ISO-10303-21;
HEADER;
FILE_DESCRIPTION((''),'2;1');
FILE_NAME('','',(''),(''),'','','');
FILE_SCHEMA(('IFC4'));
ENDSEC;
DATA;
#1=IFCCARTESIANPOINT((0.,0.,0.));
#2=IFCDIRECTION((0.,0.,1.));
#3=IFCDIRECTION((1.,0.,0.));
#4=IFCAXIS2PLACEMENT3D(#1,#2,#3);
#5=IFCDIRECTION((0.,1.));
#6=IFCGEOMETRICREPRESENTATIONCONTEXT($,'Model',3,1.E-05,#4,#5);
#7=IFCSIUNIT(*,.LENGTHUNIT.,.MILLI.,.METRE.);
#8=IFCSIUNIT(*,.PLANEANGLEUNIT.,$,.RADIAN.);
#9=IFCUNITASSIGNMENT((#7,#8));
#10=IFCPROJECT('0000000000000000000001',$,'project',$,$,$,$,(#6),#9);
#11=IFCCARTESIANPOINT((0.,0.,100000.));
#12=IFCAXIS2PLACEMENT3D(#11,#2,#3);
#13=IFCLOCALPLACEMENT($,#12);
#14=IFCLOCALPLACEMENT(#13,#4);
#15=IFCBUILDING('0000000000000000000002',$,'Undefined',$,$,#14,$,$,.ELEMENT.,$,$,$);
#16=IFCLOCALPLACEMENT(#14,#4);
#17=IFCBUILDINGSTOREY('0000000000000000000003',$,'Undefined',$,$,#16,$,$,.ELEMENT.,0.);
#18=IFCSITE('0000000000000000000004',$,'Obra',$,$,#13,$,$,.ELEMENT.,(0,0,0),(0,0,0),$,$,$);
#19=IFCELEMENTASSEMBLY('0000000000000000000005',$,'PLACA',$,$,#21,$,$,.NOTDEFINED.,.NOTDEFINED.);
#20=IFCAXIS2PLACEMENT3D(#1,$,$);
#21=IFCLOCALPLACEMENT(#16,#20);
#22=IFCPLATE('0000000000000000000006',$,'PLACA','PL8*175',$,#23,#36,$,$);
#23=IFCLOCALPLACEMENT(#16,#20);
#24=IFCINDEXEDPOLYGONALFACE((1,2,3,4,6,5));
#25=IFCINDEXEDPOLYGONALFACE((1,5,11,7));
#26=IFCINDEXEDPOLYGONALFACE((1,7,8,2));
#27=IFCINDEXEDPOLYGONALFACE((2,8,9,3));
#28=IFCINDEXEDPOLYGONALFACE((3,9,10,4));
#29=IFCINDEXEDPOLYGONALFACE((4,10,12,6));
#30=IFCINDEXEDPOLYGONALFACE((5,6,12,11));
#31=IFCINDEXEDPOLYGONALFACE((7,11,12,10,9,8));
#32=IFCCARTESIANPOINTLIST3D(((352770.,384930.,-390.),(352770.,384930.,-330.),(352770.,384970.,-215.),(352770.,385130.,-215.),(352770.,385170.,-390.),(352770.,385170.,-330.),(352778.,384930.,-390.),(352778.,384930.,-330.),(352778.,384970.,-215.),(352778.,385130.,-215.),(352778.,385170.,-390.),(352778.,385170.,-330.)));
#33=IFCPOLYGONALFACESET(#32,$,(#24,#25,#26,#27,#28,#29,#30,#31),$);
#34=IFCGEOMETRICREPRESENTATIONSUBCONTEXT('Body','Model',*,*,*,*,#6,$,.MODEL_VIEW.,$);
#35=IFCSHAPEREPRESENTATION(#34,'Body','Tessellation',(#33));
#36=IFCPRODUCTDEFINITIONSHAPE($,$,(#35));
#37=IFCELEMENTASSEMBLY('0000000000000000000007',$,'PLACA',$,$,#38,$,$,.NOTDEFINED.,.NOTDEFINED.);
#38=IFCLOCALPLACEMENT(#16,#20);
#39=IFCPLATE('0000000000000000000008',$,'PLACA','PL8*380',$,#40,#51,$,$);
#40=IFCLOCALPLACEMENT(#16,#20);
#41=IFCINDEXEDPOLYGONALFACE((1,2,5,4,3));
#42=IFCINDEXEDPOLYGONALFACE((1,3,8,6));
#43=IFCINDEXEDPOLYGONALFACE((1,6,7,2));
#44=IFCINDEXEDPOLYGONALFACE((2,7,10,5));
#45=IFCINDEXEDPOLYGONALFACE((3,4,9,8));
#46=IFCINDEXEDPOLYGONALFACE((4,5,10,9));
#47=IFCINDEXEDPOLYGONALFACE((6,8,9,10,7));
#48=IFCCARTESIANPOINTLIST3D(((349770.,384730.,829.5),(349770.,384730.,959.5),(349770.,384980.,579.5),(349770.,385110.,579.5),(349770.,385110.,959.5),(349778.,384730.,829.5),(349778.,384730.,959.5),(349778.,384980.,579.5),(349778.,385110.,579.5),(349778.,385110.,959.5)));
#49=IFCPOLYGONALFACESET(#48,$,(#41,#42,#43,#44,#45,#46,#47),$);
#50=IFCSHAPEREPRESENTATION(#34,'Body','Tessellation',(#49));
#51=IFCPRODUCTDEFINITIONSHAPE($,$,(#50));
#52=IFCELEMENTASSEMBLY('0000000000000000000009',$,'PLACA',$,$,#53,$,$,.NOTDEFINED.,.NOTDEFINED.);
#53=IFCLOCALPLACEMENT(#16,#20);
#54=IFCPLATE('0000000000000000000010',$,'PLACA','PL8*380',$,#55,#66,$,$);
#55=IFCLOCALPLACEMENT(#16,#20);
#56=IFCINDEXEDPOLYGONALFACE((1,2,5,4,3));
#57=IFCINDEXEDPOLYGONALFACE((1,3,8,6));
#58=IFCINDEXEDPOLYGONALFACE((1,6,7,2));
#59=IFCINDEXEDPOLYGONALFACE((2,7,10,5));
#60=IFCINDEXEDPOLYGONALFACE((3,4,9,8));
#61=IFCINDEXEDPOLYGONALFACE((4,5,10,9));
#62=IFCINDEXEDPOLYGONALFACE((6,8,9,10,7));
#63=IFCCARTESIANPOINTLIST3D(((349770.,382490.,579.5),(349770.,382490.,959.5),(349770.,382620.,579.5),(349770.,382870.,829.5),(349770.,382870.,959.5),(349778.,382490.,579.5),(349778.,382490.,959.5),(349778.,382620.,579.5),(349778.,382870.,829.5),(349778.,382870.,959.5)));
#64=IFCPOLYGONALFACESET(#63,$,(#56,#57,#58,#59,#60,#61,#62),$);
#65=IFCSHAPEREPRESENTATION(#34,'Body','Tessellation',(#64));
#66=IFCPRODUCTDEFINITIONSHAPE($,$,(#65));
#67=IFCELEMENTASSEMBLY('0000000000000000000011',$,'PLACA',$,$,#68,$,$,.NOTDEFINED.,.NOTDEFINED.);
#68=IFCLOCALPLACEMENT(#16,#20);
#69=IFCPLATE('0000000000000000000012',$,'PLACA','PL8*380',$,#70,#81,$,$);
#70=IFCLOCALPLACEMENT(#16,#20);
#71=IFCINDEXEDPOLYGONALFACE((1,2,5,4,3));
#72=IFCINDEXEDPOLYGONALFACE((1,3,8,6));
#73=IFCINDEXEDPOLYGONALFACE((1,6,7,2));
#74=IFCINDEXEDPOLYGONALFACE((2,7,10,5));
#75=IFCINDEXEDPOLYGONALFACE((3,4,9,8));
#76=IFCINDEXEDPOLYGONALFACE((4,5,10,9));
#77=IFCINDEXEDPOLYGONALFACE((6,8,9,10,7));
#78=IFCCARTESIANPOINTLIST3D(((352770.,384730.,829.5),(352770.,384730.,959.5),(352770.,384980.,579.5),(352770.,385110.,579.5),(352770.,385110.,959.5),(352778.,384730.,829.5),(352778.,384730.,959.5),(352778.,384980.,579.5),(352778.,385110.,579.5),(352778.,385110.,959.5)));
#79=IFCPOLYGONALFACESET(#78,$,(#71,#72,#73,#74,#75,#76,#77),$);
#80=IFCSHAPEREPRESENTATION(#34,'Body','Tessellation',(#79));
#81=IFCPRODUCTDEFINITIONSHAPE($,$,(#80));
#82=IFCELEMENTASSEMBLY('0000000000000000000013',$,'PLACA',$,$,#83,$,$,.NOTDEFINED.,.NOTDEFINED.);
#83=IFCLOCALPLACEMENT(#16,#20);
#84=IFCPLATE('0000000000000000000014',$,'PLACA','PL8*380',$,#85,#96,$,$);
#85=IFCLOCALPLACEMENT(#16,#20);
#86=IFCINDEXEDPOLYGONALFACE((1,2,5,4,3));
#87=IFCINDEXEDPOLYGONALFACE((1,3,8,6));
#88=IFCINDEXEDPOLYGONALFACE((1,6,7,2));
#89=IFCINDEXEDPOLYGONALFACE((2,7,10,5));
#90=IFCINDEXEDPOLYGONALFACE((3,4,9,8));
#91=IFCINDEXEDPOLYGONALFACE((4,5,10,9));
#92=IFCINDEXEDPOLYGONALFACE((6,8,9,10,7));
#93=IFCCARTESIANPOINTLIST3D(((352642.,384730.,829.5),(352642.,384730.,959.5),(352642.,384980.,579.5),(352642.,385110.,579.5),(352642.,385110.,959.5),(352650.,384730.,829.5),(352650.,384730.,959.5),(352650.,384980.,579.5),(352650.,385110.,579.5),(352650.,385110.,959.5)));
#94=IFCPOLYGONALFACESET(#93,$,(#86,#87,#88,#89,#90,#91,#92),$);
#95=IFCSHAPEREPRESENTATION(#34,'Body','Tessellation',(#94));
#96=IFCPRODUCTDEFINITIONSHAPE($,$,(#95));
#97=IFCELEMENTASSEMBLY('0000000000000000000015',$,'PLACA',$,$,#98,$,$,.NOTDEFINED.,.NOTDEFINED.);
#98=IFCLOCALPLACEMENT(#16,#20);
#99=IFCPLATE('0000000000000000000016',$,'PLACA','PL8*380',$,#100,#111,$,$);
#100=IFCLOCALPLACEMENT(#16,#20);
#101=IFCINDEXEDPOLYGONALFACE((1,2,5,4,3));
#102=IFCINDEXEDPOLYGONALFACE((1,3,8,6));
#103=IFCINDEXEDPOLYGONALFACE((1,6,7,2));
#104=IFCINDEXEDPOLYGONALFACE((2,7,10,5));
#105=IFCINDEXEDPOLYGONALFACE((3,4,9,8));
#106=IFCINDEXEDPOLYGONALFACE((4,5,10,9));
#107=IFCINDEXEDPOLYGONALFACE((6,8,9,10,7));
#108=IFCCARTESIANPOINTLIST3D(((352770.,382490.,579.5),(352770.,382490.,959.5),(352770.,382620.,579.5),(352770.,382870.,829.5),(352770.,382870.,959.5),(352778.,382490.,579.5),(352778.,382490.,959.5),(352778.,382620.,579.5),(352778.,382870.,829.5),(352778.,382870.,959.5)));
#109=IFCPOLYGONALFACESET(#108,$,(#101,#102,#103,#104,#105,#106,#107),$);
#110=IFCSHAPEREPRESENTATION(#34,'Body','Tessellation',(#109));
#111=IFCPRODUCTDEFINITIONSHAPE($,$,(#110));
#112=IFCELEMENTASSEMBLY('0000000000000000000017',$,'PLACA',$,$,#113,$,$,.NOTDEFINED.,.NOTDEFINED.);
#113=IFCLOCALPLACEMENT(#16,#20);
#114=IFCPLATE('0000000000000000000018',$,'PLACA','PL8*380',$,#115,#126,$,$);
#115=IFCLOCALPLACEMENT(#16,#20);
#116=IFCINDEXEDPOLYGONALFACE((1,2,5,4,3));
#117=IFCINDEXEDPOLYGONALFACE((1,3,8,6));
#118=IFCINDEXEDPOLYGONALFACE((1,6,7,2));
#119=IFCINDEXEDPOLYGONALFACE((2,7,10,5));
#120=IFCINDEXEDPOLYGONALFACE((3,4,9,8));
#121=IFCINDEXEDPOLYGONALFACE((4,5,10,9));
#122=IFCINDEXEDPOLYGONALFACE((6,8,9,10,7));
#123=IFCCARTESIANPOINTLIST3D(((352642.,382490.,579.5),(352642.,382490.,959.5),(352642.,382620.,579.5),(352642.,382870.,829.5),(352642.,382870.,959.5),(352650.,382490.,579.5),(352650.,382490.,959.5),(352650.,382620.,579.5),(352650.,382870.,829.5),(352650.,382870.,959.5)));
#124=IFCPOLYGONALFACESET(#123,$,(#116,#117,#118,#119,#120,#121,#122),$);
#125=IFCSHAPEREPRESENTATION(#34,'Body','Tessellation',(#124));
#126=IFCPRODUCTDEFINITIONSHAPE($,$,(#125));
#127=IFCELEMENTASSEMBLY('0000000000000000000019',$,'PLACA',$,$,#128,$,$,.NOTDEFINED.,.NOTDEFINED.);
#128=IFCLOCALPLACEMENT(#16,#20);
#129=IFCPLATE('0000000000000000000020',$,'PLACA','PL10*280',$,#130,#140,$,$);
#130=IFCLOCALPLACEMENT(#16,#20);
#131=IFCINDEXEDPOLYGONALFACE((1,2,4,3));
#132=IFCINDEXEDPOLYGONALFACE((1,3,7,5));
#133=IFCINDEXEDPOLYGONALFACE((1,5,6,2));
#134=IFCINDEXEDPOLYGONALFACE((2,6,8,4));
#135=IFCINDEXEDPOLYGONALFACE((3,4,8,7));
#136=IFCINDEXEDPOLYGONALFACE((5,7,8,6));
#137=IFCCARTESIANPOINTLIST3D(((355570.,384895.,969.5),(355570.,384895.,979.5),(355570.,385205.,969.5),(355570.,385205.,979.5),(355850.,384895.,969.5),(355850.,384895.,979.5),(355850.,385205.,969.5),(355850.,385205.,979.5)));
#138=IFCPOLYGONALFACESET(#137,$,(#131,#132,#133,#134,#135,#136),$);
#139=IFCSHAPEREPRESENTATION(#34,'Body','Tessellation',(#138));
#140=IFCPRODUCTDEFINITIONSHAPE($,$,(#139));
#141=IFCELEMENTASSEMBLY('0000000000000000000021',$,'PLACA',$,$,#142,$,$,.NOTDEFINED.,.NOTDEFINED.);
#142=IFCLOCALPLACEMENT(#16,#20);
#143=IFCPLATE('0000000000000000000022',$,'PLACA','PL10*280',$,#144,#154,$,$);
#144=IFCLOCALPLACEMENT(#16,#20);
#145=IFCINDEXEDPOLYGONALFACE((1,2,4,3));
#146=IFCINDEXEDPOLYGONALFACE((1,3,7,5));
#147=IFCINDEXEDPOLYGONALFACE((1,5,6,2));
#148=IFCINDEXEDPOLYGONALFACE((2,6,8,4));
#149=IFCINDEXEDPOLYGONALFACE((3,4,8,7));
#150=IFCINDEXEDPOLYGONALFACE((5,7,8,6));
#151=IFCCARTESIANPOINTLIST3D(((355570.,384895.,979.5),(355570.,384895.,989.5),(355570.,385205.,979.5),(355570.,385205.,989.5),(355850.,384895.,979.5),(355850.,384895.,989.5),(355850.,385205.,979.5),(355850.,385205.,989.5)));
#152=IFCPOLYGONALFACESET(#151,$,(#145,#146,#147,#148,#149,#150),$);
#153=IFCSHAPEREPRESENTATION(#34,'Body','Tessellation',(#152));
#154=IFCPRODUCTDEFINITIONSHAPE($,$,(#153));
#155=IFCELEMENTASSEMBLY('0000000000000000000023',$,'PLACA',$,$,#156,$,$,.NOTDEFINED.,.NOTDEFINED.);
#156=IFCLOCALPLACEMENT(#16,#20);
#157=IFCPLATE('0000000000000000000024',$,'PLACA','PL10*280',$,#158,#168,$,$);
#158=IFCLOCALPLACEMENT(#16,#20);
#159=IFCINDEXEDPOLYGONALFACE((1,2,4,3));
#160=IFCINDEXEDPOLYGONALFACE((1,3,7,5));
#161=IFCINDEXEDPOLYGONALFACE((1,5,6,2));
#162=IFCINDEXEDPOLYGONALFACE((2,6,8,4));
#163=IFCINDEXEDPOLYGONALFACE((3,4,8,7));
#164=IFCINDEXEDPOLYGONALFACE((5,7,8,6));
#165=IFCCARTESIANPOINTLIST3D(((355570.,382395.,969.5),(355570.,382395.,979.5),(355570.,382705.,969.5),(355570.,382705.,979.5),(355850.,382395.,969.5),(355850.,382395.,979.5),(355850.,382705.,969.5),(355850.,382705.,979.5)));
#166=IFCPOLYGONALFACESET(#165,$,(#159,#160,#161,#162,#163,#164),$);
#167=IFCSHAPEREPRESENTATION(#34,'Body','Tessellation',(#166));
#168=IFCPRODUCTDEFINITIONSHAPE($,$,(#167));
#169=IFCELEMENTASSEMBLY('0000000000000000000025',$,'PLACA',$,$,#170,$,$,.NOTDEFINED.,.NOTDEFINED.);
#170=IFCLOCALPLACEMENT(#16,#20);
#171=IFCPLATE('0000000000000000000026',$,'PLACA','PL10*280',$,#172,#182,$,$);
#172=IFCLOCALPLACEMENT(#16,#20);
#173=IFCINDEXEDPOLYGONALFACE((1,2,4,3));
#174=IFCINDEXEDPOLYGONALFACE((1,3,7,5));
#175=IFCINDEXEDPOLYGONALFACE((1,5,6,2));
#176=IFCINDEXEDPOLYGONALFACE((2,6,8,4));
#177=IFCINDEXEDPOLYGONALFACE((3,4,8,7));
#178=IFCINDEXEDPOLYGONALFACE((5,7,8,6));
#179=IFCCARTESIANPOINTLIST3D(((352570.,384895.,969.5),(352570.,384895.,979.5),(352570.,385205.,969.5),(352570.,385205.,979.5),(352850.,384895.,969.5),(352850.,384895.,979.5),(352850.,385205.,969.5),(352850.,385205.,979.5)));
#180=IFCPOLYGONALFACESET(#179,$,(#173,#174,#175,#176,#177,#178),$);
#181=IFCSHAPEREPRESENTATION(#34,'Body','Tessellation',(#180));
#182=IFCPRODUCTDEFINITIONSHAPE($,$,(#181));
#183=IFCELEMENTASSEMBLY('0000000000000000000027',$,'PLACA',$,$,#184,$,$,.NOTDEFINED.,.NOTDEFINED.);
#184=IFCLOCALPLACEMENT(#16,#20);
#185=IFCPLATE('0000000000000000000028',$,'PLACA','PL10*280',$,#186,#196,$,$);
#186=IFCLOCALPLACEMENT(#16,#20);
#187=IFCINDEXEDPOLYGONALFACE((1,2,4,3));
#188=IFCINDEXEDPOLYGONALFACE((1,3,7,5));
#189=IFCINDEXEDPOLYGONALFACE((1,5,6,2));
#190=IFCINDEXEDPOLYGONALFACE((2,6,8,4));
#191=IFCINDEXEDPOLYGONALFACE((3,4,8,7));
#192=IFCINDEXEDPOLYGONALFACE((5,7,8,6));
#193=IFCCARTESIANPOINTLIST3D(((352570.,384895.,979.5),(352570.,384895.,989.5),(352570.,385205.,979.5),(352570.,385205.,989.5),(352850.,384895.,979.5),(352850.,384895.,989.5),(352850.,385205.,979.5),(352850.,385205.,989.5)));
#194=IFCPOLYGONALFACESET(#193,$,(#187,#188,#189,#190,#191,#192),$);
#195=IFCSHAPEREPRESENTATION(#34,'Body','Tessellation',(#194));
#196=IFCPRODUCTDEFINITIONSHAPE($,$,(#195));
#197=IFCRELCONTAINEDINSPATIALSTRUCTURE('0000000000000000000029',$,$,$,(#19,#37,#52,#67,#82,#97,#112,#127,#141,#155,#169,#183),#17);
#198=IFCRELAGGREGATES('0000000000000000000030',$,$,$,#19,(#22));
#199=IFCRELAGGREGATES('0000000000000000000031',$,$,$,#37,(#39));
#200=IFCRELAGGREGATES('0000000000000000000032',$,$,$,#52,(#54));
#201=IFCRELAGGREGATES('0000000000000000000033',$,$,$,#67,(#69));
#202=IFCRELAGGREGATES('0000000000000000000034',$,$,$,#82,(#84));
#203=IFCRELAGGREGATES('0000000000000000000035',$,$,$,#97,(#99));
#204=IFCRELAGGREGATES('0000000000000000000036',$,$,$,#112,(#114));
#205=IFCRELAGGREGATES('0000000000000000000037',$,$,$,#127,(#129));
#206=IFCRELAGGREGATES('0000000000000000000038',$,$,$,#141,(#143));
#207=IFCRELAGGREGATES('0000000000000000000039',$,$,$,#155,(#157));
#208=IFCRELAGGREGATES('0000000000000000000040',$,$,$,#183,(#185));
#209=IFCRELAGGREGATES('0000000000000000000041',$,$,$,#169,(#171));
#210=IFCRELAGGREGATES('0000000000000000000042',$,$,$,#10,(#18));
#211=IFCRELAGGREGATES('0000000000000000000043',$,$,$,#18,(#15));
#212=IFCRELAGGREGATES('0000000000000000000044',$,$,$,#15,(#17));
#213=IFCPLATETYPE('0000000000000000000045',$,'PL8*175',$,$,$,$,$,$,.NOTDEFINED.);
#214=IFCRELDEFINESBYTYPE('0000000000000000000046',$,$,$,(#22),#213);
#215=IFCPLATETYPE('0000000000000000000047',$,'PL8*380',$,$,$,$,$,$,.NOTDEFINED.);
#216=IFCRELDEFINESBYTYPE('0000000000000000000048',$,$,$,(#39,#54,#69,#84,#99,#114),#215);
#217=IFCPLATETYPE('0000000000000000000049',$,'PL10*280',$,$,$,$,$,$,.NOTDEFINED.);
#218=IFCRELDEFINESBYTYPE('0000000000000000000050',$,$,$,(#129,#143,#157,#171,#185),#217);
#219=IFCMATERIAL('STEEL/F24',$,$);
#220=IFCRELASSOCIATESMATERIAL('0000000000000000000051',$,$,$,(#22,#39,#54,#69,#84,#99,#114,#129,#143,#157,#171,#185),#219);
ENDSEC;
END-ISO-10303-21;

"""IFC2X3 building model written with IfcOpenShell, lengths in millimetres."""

from ifc_helpers import new_model, si_unit, direction, frame, origin_with_axes, place, context, subcontext, project, spatial, polyline, outline, extrude, material, type_object, element, aggregate, save


model = new_model("IFC2X3")

# Units and contexts
model_context = context("Model", 3, precision=1e-05, world=origin_with_axes(), true_north=direction((0.0, 1.0)))
body_context = subcontext(model_context, "Body", "Model", "MODEL_VIEW")
ifc_project = project(units=[si_unit("LENGTHUNIT", "METRE", prefix="MILLI"), si_unit("PLANEANGLEUNIT", "RADIAN")], contexts=[model_context])

# Site, building, storey
site_placement = place(None, frame((0.0, 0.0, 100000.0), z_axis=(0.0, 0.0, 1.0), x_axis=(1.0, 0.0, 0.0)))
site = spatial("IfcSite", under=ifc_project, at=site_placement, Name="Obra", CompositionType="ELEMENT", RefLatitude=(0, 0, 0), RefLongitude=(0, 0, 0))
building_placement = place(site_placement, origin_with_axes())
building = spatial("IfcBuilding", under=site, at=building_placement, Name="Undefined", CompositionType="ELEMENT")
storey_placement = place(building_placement, origin_with_axes())
storey = spatial("IfcBuildingStorey", under=building, at=storey_placement, Name="Undefined", CompositionType="ELEMENT", Elevation=0.0)

# Shared definitions
ifc_material_1 = material(Name="STEEL/F24")

# Element assemblies, plates
plate_type_1 = type_object("IfcPlateType", Name="PL8*175", PredefinedType="NOTDEFINED")
assembly_1_placement = place(storey_placement, origin_with_axes())
assembly_1 = element("IfcElementAssembly", 1, at=assembly_1_placement, inside=storey, Name="PLACA", AssemblyPlace="NOTDEFINED", PredefinedType="NOTDEFINED")
plate_1_placement = place(assembly_1_placement, frame((352774.0, 385130.0, -215.0), z_axis=(-1.0, 0.0, 0.0), x_axis=(0.0, 0.328521, -0.944497)))
plate_1 = element("IfcPlate", 2, at=plate_1_placement, type_object=plate_type_1, material=ifc_material_1, Name="PLACA", Description="PL8*175", context=body_context, shape_type="SweptSolid", body=[
    extrude(outline(polyline([(0.0, 0.0), (121.8, 0.0), (178.4, 19.7), (99.6, 246.4), (42.9, 226.7), (-52.6, 151.1), (0.0, 0.0)])), frame((0.0, 0.0, -4.0), z_axis=(0.0, 0.0, 1.0), x_axis=(1.0, 0.0, 0.0)), (0.0, 0.0, 1.0), 8.0),
])
aggregate(assembly_1, [plate_1])
assembly_2_placement = place(storey_placement, origin_with_axes())
assembly_2 = element("IfcElementAssembly", 3, at=assembly_2_placement, inside=storey, Name="PLACA", AssemblyPlace="NOTDEFINED", PredefinedType="NOTDEFINED")
plate_type_2 = type_object("IfcPlateType", Name="PL8*380", PredefinedType="NOTDEFINED")
plate_2_placement = place(assembly_2_placement, frame((349774.0, 384730.0, 959.5), z_axis=(-1.0, 0.0, 0.0), x_axis=(0.0, 1.0, 0.0)))
plate_2 = element("IfcPlate", 4, at=plate_2_placement, type_object=plate_type_2, material=ifc_material_1, Name="PLACA", Description="PL8*380", context=body_context, shape_type="SweptSolid", body=[
    extrude(outline(polyline([(0.0, 0.0), (380.0, 0.0), (380.0, 380.0), (250.0, 380.0), (0.0, 130.0), (0.0, 0.0)])), frame((0.0, 0.0, -4.0), z_axis=(0.0, 0.0, 1.0), x_axis=(1.0, 0.0, 0.0)), (0.0, 0.0, 1.0), 8.0),
])
aggregate(assembly_2, [plate_2])
assembly_3_placement = place(storey_placement, origin_with_axes())
assembly_3 = element("IfcElementAssembly", 5, at=assembly_3_placement, inside=storey, Name="PLACA", AssemblyPlace="NOTDEFINED", PredefinedType="NOTDEFINED")
plate_3_placement = place(assembly_3_placement, frame((349774.0, 382870.0, 959.5), z_axis=(1.0, 0.0, 0.0), x_axis=(0.0, -1.0, 0.0)))
plate_3 = element("IfcPlate", 6, at=plate_3_placement, type_object=plate_type_2, material=ifc_material_1, Name="PLACA", Description="PL8*380", context=body_context, shape_type="SweptSolid", body=[
    extrude(outline(polyline([(0.0, 0.0), (380.0, 0.0), (380.0, 380.0), (250.0, 380.0), (0.0, 130.0), (0.0, 0.0)])), frame((0.0, 0.0, -4.0), z_axis=(0.0, 0.0, 1.0), x_axis=(1.0, 0.0, 0.0)), (0.0, 0.0, 1.0), 8.0),
])
aggregate(assembly_3, [plate_3])
assembly_4_placement = place(storey_placement, origin_with_axes())
assembly_4 = element("IfcElementAssembly", 7, at=assembly_4_placement, inside=storey, Name="PLACA", AssemblyPlace="NOTDEFINED", PredefinedType="NOTDEFINED")
plate_4_placement = place(assembly_4_placement, frame((352774.0, 384730.0, 959.5), z_axis=(-1.0, 0.0, 0.0), x_axis=(0.0, 1.0, 0.0)))
plate_4 = element("IfcPlate", 8, at=plate_4_placement, type_object=plate_type_2, material=ifc_material_1, Name="PLACA", Description="PL8*380", context=body_context, shape_type="SweptSolid", body=[
    extrude(outline(polyline([(0.0, 0.0), (380.0, 0.0), (380.0, 380.0), (250.0, 380.0), (0.0, 130.0), (0.0, 0.0)])), frame((0.0, 0.0, -4.0), z_axis=(0.0, 0.0, 1.0), x_axis=(1.0, 0.0, 0.0)), (0.0, 0.0, 1.0), 8.0),
])
aggregate(assembly_4, [plate_4])
assembly_5_placement = place(storey_placement, origin_with_axes())
assembly_5 = element("IfcElementAssembly", 9, at=assembly_5_placement, inside=storey, Name="PLACA", AssemblyPlace="NOTDEFINED", PredefinedType="NOTDEFINED")
plate_5_placement = place(assembly_5_placement, frame((352646.0, 384730.0, 959.5), z_axis=(-1.0, 0.0, 0.0), x_axis=(0.0, 1.0, 0.0)))
plate_5 = element("IfcPlate", 10, at=plate_5_placement, type_object=plate_type_2, material=ifc_material_1, Name="PLACA", Description="PL8*380", context=body_context, shape_type="SweptSolid", body=[
    extrude(outline(polyline([(0.0, 0.0), (380.0, 0.0), (380.0, 380.0), (250.0, 380.0), (0.0, 130.0), (0.0, 0.0)])), frame((0.0, 0.0, -4.0), z_axis=(0.0, 0.0, 1.0), x_axis=(1.0, 0.0, 0.0)), (0.0, 0.0, 1.0), 8.0),
])
aggregate(assembly_5, [plate_5])
assembly_6_placement = place(storey_placement, origin_with_axes())
assembly_6 = element("IfcElementAssembly", 11, at=assembly_6_placement, inside=storey, Name="PLACA", AssemblyPlace="NOTDEFINED", PredefinedType="NOTDEFINED")
plate_6_placement = place(assembly_6_placement, frame((352774.0, 382870.0, 959.5), z_axis=(1.0, 0.0, 0.0), x_axis=(0.0, -1.0, 0.0)))
plate_6 = element("IfcPlate", 12, at=plate_6_placement, type_object=plate_type_2, material=ifc_material_1, Name="PLACA", Description="PL8*380", context=body_context, shape_type="SweptSolid", body=[
    extrude(outline(polyline([(0.0, 0.0), (380.0, 0.0), (380.0, 380.0), (250.0, 380.0), (0.0, 130.0), (0.0, 0.0)])), frame((0.0, 0.0, -4.0), z_axis=(0.0, 0.0, 1.0), x_axis=(1.0, 0.0, 0.0)), (0.0, 0.0, 1.0), 8.0),
])
aggregate(assembly_6, [plate_6])
assembly_7_placement = place(storey_placement, origin_with_axes())
assembly_7 = element("IfcElementAssembly", 13, at=assembly_7_placement, inside=storey, Name="PLACA", AssemblyPlace="NOTDEFINED", PredefinedType="NOTDEFINED")
plate_7_placement = place(assembly_7_placement, frame((352646.0, 382870.0, 959.5), z_axis=(1.0, 0.0, 0.0), x_axis=(0.0, -1.0, 0.0)))
plate_7 = element("IfcPlate", 14, at=plate_7_placement, type_object=plate_type_2, material=ifc_material_1, Name="PLACA", Description="PL8*380", context=body_context, shape_type="SweptSolid", body=[
    extrude(outline(polyline([(0.0, 0.0), (380.0, 0.0), (380.0, 380.0), (250.0, 380.0), (0.0, 130.0), (0.0, 0.0)])), frame((0.0, 0.0, -4.0), z_axis=(0.0, 0.0, 1.0), x_axis=(1.0, 0.0, 0.0)), (0.0, 0.0, 1.0), 8.0),
])
aggregate(assembly_7, [plate_7])
assembly_8_placement = place(storey_placement, origin_with_axes())
assembly_8 = element("IfcElementAssembly", 15, at=assembly_8_placement, inside=storey, Name="PLACA", AssemblyPlace="NOTDEFINED", PredefinedType="NOTDEFINED")
plate_type_3 = type_object("IfcPlateType", Name="PL10*280", PredefinedType="NOTDEFINED")
plate_8_placement = place(assembly_8_placement, frame((355570.0, 385205.0, 974.5), z_axis=(0.0, 0.0, -1.0), x_axis=(1.0, 0.0, 0.0)))
plate_8 = element("IfcPlate", 16, at=plate_8_placement, type_object=plate_type_3, material=ifc_material_1, Name="PLACA", Description="PL10*280", context=body_context, shape_type="SweptSolid", body=[
    extrude(outline(polyline([(0.0, 0.0), (280.0, 0.0), (280.0, 310.0), (0.0, 310.0), (0.0, 0.0)])), frame((0.0, 0.0, -5.0), z_axis=(0.0, 0.0, 1.0), x_axis=(1.0, 0.0, 0.0)), (0.0, 0.0, 1.0), 10.0),
])
aggregate(assembly_8, [plate_8])
assembly_9_placement = place(storey_placement, origin_with_axes())
assembly_9 = element("IfcElementAssembly", 17, at=assembly_9_placement, inside=storey, Name="PLACA", AssemblyPlace="NOTDEFINED", PredefinedType="NOTDEFINED")
plate_9_placement = place(assembly_9_placement, frame((355570.0, 385205.0, 984.5), z_axis=(0.0, 0.0, -1.0), x_axis=(1.0, 0.0, 0.0)))
plate_9 = element("IfcPlate", 18, at=plate_9_placement, type_object=plate_type_3, material=ifc_material_1, Name="PLACA", Description="PL10*280", context=body_context, shape_type="SweptSolid", body=[
    extrude(outline(polyline([(0.0, 0.0), (280.0, 0.0), (280.0, 310.0), (0.0, 310.0), (0.0, 0.0)])), frame((0.0, 0.0, -5.0), z_axis=(0.0, 0.0, 1.0), x_axis=(1.0, 0.0, 0.0)), (0.0, 0.0, 1.0), 10.0),
])
aggregate(assembly_9, [plate_9])
assembly_10_placement = place(storey_placement, origin_with_axes())
assembly_10 = element("IfcElementAssembly", 19, at=assembly_10_placement, inside=storey, Name="PLACA", AssemblyPlace="NOTDEFINED", PredefinedType="NOTDEFINED")
plate_10_placement = place(assembly_10_placement, frame((355570.0, 382395.0, 974.5), z_axis=(0.0, 0.0, 1.0), x_axis=(1.0, 0.0, 0.0)))
plate_10 = element("IfcPlate", 20, at=plate_10_placement, type_object=plate_type_3, material=ifc_material_1, Name="PLACA", Description="PL10*280", context=body_context, shape_type="SweptSolid", body=[
    extrude(outline(polyline([(0.0, 0.0), (280.0, 0.0), (280.0, 310.0), (0.0, 310.0), (0.0, 0.0)])), frame((0.0, 0.0, -5.0), z_axis=(0.0, 0.0, 1.0), x_axis=(1.0, 0.0, 0.0)), (0.0, 0.0, 1.0), 10.0),
])
aggregate(assembly_10, [plate_10])
assembly_11_placement = place(storey_placement, origin_with_axes())
assembly_11 = element("IfcElementAssembly", 21, at=assembly_11_placement, inside=storey, Name="PLACA", AssemblyPlace="NOTDEFINED", PredefinedType="NOTDEFINED")
plate_11_placement = place(assembly_11_placement, frame((352570.0, 385205.0, 974.5), z_axis=(0.0, 0.0, -1.0), x_axis=(1.0, 0.0, 0.0)))
plate_11 = element("IfcPlate", 22, at=plate_11_placement, type_object=plate_type_3, material=ifc_material_1, Name="PLACA", Description="PL10*280", context=body_context, shape_type="SweptSolid", body=[
    extrude(outline(polyline([(0.0, 0.0), (280.0, 0.0), (280.0, 310.0), (0.0, 310.0), (0.0, 0.0)])), frame((0.0, 0.0, -5.0), z_axis=(0.0, 0.0, 1.0), x_axis=(1.0, 0.0, 0.0)), (0.0, 0.0, 1.0), 10.0),
])
assembly_12_placement = place(storey_placement, origin_with_axes())
assembly_12 = element("IfcElementAssembly", 23, at=assembly_12_placement, inside=storey, Name="PLACA", AssemblyPlace="NOTDEFINED", PredefinedType="NOTDEFINED")
plate_12_placement = place(assembly_12_placement, frame((352570.0, 385205.0, 984.5), z_axis=(0.0, 0.0, -1.0), x_axis=(1.0, 0.0, 0.0)))
plate_12 = element("IfcPlate", 24, at=plate_12_placement, type_object=plate_type_3, material=ifc_material_1, Name="PLACA", Description="PL10*280", context=body_context, shape_type="SweptSolid", body=[
    extrude(outline(polyline([(0.0, 0.0), (280.0, 0.0), (280.0, 310.0), (0.0, 310.0), (0.0, 0.0)])), frame((0.0, 0.0, -5.0), z_axis=(0.0, 0.0, 1.0), x_axis=(1.0, 0.0, 0.0)), (0.0, 0.0, 1.0), 10.0),
])
aggregate(assembly_12, [plate_12])

aggregate(assembly_11, [plate_11])

save(model, "model.ifc")
